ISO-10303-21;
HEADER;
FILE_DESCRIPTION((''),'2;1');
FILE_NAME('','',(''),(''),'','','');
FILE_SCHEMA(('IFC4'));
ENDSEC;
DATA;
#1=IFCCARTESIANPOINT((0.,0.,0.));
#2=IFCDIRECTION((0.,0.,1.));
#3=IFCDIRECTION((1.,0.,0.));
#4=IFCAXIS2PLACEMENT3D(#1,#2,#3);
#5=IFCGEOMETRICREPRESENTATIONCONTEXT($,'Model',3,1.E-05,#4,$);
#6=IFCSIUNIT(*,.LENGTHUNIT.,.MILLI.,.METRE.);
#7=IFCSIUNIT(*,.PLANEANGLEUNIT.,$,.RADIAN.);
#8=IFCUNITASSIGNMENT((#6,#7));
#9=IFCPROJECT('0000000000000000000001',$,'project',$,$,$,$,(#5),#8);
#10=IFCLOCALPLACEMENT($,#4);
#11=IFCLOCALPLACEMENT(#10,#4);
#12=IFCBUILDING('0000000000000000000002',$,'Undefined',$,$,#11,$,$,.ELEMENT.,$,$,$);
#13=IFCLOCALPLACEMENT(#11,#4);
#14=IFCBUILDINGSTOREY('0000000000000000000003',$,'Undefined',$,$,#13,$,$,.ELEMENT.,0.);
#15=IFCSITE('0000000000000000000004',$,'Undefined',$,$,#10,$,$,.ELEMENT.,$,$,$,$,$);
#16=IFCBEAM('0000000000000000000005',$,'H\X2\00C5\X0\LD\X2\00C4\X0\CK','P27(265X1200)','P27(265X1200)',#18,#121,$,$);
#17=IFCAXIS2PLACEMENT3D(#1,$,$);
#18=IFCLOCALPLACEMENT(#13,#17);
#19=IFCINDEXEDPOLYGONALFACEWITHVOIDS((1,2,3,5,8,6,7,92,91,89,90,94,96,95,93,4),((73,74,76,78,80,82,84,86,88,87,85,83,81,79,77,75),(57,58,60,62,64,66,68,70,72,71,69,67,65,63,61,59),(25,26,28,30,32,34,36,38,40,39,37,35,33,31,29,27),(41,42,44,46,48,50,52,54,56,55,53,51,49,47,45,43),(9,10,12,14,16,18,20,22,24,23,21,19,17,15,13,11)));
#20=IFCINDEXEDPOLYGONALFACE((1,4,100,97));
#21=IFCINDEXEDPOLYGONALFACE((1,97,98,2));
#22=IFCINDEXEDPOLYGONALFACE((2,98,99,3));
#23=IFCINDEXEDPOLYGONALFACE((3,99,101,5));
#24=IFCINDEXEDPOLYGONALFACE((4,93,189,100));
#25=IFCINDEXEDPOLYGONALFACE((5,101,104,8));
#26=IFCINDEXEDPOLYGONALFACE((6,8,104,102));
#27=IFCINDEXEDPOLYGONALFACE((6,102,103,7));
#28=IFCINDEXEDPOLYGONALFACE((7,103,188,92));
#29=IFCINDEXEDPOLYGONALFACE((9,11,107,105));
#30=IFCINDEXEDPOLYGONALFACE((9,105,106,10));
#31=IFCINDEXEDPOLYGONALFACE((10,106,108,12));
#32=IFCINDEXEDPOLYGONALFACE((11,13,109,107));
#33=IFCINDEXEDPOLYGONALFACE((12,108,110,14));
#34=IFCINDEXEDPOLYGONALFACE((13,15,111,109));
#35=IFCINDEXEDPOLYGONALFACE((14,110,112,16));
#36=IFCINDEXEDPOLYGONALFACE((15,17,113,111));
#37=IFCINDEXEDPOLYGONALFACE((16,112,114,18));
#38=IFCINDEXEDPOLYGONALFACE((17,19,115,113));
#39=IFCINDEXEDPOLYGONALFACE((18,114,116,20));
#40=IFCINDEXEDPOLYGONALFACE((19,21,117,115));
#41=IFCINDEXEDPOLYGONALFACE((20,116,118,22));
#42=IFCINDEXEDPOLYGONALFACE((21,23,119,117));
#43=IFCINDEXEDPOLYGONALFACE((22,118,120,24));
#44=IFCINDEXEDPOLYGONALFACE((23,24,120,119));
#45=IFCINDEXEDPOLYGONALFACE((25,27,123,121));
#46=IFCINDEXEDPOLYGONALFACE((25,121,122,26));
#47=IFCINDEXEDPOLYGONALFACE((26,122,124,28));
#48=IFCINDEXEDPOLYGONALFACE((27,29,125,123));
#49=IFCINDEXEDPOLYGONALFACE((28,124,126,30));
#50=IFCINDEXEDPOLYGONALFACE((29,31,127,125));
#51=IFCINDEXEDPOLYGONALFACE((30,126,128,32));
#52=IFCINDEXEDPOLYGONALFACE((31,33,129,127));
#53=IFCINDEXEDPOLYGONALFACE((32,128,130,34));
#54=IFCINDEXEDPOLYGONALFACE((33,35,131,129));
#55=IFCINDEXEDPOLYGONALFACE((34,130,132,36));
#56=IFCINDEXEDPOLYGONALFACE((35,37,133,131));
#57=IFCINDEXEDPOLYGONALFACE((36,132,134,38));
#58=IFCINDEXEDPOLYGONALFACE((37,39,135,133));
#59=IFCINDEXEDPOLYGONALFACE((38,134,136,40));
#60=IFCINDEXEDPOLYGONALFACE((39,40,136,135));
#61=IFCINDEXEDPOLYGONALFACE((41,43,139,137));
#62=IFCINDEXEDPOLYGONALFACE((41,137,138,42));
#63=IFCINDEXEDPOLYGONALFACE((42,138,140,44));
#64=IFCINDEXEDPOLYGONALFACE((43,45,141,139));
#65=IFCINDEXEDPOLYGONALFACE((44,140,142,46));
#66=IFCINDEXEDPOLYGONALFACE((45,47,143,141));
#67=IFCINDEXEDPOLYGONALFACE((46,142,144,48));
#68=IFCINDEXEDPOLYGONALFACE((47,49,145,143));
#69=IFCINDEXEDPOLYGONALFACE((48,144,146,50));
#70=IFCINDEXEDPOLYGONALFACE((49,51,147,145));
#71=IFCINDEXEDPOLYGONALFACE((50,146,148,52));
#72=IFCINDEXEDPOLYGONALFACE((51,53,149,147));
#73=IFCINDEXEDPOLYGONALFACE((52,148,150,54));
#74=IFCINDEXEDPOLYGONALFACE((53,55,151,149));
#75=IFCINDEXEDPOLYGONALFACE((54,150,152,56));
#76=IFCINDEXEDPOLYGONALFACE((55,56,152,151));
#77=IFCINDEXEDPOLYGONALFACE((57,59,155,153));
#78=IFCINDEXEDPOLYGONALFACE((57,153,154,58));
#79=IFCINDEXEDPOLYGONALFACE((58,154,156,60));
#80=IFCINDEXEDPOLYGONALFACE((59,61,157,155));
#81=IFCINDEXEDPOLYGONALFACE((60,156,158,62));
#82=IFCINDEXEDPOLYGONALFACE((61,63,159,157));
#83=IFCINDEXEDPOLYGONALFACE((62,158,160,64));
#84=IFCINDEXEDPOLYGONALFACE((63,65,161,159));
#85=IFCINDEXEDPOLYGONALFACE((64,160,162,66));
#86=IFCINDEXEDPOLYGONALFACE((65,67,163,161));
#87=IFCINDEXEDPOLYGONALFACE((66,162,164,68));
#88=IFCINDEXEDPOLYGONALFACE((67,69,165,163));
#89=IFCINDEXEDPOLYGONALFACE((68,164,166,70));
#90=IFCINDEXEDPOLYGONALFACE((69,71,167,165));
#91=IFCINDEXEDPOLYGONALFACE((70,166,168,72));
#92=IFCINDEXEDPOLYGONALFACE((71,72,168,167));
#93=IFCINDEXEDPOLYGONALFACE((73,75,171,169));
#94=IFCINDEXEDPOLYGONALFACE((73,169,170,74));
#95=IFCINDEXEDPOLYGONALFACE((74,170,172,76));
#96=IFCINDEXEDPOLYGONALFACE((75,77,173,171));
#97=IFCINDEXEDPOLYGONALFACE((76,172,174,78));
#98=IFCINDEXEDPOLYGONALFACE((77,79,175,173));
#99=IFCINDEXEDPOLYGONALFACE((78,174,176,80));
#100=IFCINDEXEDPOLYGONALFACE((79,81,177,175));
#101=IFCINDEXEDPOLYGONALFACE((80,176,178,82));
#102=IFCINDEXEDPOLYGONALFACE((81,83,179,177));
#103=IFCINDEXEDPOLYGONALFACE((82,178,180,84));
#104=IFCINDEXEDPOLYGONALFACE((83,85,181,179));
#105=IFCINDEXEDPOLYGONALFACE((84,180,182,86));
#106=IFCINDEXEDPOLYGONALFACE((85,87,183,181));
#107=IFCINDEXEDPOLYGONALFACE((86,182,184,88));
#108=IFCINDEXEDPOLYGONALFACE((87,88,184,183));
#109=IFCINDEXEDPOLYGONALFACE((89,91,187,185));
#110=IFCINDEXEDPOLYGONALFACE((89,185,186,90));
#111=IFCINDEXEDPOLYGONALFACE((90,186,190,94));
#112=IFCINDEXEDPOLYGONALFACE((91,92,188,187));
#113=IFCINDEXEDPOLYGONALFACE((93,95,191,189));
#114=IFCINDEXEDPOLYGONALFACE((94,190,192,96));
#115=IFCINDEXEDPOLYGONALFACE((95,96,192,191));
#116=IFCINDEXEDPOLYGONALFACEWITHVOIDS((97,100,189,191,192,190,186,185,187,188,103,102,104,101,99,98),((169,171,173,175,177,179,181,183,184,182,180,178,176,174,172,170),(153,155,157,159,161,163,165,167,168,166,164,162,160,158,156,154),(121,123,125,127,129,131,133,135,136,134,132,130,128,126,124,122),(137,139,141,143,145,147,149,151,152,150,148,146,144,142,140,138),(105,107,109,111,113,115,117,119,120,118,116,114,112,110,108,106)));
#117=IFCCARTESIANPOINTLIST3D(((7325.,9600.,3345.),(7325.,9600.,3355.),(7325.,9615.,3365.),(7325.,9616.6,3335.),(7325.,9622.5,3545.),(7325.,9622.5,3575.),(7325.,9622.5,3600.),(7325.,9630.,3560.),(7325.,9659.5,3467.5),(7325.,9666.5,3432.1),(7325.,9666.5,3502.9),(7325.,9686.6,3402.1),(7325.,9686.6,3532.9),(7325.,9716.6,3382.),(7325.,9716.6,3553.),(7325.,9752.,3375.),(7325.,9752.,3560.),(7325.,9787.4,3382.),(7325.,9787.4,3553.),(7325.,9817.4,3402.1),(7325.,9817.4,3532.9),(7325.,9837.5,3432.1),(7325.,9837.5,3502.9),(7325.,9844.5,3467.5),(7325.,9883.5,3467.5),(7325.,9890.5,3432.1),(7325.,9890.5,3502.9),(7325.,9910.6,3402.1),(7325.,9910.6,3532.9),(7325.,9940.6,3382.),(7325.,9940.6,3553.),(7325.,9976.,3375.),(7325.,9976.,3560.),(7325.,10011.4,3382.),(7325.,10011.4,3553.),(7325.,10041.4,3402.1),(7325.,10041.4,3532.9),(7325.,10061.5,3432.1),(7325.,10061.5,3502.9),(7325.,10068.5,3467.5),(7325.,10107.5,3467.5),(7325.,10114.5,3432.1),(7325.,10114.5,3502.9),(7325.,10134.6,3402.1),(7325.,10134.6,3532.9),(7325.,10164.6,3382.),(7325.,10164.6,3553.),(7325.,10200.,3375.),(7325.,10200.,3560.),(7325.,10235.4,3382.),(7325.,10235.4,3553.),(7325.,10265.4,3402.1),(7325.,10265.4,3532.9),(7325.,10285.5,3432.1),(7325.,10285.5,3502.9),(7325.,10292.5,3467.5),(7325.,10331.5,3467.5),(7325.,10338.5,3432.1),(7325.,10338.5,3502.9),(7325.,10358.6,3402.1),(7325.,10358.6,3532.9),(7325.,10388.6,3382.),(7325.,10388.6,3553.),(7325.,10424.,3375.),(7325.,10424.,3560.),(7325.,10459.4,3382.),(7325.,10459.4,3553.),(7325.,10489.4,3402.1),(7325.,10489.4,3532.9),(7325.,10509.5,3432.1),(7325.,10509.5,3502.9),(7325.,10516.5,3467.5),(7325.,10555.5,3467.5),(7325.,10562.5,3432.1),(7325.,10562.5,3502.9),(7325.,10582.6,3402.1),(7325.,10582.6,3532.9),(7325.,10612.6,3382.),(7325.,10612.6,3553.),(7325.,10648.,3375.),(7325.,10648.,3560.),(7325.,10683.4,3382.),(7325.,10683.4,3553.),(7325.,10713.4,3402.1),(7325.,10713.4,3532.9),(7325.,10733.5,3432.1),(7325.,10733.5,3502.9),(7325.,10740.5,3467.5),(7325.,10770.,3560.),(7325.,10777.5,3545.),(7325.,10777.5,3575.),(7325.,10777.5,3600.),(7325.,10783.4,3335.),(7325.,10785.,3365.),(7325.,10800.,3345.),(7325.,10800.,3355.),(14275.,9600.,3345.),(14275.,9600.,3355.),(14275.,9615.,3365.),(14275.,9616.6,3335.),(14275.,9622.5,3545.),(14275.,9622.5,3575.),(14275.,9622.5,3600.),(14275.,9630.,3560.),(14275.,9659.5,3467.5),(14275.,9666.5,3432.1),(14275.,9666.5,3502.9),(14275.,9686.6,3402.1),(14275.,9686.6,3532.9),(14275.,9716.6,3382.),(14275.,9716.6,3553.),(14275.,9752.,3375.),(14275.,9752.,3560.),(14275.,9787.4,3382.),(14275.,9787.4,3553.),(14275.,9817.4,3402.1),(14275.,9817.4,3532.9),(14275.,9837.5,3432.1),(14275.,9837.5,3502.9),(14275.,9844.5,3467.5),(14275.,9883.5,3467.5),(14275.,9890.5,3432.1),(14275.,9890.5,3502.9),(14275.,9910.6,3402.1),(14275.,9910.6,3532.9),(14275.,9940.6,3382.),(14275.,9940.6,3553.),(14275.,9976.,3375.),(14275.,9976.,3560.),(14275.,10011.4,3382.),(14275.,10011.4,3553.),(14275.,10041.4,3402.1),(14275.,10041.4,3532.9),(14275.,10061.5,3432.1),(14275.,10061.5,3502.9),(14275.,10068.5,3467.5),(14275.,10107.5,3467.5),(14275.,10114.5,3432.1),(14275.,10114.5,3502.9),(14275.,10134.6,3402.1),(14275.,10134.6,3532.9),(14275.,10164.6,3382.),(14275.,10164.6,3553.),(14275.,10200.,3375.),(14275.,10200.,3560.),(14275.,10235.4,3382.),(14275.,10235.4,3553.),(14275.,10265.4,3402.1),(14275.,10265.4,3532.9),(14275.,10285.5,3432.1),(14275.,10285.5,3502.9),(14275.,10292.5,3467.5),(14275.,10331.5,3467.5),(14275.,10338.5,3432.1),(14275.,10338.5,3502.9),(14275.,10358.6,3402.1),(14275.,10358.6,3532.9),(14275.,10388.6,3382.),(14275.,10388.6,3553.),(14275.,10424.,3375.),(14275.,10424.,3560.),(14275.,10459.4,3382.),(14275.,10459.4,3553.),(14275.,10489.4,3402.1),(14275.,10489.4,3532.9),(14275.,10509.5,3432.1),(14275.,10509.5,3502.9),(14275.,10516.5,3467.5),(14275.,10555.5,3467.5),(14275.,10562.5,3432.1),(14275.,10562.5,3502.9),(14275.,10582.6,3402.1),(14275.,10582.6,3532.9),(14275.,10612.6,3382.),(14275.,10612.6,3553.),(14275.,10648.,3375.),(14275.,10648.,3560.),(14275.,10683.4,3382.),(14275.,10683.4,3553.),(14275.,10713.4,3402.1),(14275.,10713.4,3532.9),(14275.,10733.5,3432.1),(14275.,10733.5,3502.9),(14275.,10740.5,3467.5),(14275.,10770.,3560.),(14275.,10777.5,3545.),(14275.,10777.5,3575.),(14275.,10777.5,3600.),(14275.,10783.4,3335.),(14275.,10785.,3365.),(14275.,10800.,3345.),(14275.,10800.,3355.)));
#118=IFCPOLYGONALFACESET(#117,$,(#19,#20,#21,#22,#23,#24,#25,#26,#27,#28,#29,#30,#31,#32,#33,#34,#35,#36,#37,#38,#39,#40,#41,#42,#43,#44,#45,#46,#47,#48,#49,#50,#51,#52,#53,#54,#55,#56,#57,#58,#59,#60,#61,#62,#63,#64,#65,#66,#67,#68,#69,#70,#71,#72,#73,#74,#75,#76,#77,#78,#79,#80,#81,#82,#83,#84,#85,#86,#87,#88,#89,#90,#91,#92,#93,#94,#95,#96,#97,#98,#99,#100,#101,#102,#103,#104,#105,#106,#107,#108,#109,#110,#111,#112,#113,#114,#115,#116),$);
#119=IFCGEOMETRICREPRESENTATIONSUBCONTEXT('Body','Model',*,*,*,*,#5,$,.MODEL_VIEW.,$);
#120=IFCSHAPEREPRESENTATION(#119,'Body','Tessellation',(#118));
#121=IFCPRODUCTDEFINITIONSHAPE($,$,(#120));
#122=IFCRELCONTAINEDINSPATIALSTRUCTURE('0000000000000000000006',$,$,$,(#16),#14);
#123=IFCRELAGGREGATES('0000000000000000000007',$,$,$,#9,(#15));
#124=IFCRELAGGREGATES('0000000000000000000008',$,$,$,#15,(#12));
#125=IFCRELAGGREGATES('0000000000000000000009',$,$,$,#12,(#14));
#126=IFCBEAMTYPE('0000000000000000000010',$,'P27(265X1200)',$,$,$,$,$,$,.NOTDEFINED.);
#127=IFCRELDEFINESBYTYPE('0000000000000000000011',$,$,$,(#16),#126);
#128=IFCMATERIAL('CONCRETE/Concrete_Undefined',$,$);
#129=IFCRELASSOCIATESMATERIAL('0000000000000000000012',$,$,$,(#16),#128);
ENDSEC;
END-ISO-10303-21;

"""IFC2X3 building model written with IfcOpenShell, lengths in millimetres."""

from ifc_helpers import new_model, si_unit, frame, origin_with_axes, place, context, subcontext, project, spatial, polyline, outline, extrude, material, type_object, element, save


model = new_model("IFC2X3")

# Units and contexts
model_context = context("Model", 3, precision=1e-05, world=origin_with_axes())
body_context = subcontext(model_context, "Body", "Model", "MODEL_VIEW")
ifc_project = project(units=[si_unit("LENGTHUNIT", "METRE", prefix="MILLI"), si_unit("PLANEANGLEUNIT", "RADIAN")], contexts=[model_context])

# Site, building, storey
site_placement = place(None, origin_with_axes())
site = spatial("IfcSite", under=ifc_project, at=site_placement, Name="Undefined", CompositionType="ELEMENT")
building_placement = place(site_placement, origin_with_axes())
building = spatial("IfcBuilding", under=site, at=building_placement, Name="Undefined", CompositionType="ELEMENT")
storey_placement = place(building_placement, origin_with_axes())
storey = spatial("IfcBuildingStorey", under=building, at=storey_placement, Name="Undefined", CompositionType="ELEMENT", Elevation=0.0)

# Beam
ifc_material_1 = material(Name="CONCRETE/Concrete_Undefined")
beam_type_1 = type_object("IfcBeamType", Name="P27(265X1200)", PredefinedType="NOTDEFINED")
beam_1_placement = place(storey_placement, frame((7325.0, 10200.0, 3467.5), z_axis=(0.0, 0.0, 1.0), x_axis=(1.0, 0.0, 0.0)))
element("IfcBeam", 1, at=beam_1_placement, inside=storey, type_object=beam_type_1, material=ifc_material_1, Name="HÅLDÄCK", Description="P27(265X1200)", ObjectType="P27(265X1200)", context=body_context, shape_type="SweptSolid", body=[
    extrude(outline(polyline([(-583.4, -132.5), (-600.0, -122.5), (-600.0, -112.5), (-585.0, -102.5), (-577.5, 77.5), (-570.0, 92.5), (-577.5, 107.5), (-577.5, 132.5), (577.5, 132.5), (577.5, 107.5), (570.0, 92.5), (577.5, 77.5), (585.0, -102.5), (600.0, -112.5), (600.0, -122.5), (583.4, -132.5), (-583.4, -132.5)]), holes=[polyline([(-513.4, 65.4), (-533.5, 35.4), (-540.5, 0.0), (-533.5, -35.4), (-513.4, -65.4), (-483.4, -85.5), (-448.0, -92.5), (-412.6, -85.5), (-382.6, -65.4), (-362.5, -35.4), (-355.5, 0.0), (-362.5, 35.4), (-382.6, 65.4), (-412.6, 85.5), (-448.0, 92.5), (-483.4, 85.5), (-513.4, 65.4)]), polyline([(-289.4, 65.4), (-309.5, 35.4), (-316.5, 0.0), (-309.5, -35.4), (-289.4, -65.4), (-259.4, -85.5), (-224.0, -92.5), (-188.6, -85.5), (-158.6, -65.4), (-138.5, -35.4), (-131.5, 0.0), (-138.5, 35.4), (-158.6, 65.4), (-188.6, 85.5), (-224.0, 92.5), (-259.4, 85.5), (-289.4, 65.4)]), polyline([(-65.4, 65.4), (-85.5, 35.4), (-92.5, 0.0), (-85.5, -35.4), (-65.4, -65.4), (-35.4, -85.5), (0.0, -92.5), (35.4, -85.5), (65.4, -65.4), (85.5, -35.4), (92.5, 0.0), (85.5, 35.4), (65.4, 65.4), (35.4, 85.5), (0.0, 92.5), (-35.4, 85.5), (-65.4, 65.4)]), polyline([(158.6, 65.4), (138.5, 35.4), (131.5, 0.0), (138.5, -35.4), (158.6, -65.4), (188.6, -85.5), (224.0, -92.5), (259.4, -85.5), (289.4, -65.4), (309.5, -35.4), (316.5, 0.0), (309.5, 35.4), (289.4, 65.4), (259.4, 85.5), (224.0, 92.5), (188.6, 85.5), (158.6, 65.4)]), polyline([(382.6, 65.4), (362.5, 35.4), (355.5, 0.0), (362.5, -35.4), (382.6, -65.4), (412.6, -85.5), (448.0, -92.5), (483.4, -85.5), (513.4, -65.4), (533.5, -35.4), (540.5, 0.0), (533.5, 35.4), (513.4, 65.4), (483.4, 85.5), (448.0, 92.5), (412.6, 85.5), (382.6, 65.4)])]), frame((6950.0, 0.0, 0.0), z_axis=(-1.0, 0.0, 0.0), x_axis=(0.0, -1.0, 0.0)), (0.0, 0.0, 1.0), 6950.0),
])

save(model, "model.ifc")
